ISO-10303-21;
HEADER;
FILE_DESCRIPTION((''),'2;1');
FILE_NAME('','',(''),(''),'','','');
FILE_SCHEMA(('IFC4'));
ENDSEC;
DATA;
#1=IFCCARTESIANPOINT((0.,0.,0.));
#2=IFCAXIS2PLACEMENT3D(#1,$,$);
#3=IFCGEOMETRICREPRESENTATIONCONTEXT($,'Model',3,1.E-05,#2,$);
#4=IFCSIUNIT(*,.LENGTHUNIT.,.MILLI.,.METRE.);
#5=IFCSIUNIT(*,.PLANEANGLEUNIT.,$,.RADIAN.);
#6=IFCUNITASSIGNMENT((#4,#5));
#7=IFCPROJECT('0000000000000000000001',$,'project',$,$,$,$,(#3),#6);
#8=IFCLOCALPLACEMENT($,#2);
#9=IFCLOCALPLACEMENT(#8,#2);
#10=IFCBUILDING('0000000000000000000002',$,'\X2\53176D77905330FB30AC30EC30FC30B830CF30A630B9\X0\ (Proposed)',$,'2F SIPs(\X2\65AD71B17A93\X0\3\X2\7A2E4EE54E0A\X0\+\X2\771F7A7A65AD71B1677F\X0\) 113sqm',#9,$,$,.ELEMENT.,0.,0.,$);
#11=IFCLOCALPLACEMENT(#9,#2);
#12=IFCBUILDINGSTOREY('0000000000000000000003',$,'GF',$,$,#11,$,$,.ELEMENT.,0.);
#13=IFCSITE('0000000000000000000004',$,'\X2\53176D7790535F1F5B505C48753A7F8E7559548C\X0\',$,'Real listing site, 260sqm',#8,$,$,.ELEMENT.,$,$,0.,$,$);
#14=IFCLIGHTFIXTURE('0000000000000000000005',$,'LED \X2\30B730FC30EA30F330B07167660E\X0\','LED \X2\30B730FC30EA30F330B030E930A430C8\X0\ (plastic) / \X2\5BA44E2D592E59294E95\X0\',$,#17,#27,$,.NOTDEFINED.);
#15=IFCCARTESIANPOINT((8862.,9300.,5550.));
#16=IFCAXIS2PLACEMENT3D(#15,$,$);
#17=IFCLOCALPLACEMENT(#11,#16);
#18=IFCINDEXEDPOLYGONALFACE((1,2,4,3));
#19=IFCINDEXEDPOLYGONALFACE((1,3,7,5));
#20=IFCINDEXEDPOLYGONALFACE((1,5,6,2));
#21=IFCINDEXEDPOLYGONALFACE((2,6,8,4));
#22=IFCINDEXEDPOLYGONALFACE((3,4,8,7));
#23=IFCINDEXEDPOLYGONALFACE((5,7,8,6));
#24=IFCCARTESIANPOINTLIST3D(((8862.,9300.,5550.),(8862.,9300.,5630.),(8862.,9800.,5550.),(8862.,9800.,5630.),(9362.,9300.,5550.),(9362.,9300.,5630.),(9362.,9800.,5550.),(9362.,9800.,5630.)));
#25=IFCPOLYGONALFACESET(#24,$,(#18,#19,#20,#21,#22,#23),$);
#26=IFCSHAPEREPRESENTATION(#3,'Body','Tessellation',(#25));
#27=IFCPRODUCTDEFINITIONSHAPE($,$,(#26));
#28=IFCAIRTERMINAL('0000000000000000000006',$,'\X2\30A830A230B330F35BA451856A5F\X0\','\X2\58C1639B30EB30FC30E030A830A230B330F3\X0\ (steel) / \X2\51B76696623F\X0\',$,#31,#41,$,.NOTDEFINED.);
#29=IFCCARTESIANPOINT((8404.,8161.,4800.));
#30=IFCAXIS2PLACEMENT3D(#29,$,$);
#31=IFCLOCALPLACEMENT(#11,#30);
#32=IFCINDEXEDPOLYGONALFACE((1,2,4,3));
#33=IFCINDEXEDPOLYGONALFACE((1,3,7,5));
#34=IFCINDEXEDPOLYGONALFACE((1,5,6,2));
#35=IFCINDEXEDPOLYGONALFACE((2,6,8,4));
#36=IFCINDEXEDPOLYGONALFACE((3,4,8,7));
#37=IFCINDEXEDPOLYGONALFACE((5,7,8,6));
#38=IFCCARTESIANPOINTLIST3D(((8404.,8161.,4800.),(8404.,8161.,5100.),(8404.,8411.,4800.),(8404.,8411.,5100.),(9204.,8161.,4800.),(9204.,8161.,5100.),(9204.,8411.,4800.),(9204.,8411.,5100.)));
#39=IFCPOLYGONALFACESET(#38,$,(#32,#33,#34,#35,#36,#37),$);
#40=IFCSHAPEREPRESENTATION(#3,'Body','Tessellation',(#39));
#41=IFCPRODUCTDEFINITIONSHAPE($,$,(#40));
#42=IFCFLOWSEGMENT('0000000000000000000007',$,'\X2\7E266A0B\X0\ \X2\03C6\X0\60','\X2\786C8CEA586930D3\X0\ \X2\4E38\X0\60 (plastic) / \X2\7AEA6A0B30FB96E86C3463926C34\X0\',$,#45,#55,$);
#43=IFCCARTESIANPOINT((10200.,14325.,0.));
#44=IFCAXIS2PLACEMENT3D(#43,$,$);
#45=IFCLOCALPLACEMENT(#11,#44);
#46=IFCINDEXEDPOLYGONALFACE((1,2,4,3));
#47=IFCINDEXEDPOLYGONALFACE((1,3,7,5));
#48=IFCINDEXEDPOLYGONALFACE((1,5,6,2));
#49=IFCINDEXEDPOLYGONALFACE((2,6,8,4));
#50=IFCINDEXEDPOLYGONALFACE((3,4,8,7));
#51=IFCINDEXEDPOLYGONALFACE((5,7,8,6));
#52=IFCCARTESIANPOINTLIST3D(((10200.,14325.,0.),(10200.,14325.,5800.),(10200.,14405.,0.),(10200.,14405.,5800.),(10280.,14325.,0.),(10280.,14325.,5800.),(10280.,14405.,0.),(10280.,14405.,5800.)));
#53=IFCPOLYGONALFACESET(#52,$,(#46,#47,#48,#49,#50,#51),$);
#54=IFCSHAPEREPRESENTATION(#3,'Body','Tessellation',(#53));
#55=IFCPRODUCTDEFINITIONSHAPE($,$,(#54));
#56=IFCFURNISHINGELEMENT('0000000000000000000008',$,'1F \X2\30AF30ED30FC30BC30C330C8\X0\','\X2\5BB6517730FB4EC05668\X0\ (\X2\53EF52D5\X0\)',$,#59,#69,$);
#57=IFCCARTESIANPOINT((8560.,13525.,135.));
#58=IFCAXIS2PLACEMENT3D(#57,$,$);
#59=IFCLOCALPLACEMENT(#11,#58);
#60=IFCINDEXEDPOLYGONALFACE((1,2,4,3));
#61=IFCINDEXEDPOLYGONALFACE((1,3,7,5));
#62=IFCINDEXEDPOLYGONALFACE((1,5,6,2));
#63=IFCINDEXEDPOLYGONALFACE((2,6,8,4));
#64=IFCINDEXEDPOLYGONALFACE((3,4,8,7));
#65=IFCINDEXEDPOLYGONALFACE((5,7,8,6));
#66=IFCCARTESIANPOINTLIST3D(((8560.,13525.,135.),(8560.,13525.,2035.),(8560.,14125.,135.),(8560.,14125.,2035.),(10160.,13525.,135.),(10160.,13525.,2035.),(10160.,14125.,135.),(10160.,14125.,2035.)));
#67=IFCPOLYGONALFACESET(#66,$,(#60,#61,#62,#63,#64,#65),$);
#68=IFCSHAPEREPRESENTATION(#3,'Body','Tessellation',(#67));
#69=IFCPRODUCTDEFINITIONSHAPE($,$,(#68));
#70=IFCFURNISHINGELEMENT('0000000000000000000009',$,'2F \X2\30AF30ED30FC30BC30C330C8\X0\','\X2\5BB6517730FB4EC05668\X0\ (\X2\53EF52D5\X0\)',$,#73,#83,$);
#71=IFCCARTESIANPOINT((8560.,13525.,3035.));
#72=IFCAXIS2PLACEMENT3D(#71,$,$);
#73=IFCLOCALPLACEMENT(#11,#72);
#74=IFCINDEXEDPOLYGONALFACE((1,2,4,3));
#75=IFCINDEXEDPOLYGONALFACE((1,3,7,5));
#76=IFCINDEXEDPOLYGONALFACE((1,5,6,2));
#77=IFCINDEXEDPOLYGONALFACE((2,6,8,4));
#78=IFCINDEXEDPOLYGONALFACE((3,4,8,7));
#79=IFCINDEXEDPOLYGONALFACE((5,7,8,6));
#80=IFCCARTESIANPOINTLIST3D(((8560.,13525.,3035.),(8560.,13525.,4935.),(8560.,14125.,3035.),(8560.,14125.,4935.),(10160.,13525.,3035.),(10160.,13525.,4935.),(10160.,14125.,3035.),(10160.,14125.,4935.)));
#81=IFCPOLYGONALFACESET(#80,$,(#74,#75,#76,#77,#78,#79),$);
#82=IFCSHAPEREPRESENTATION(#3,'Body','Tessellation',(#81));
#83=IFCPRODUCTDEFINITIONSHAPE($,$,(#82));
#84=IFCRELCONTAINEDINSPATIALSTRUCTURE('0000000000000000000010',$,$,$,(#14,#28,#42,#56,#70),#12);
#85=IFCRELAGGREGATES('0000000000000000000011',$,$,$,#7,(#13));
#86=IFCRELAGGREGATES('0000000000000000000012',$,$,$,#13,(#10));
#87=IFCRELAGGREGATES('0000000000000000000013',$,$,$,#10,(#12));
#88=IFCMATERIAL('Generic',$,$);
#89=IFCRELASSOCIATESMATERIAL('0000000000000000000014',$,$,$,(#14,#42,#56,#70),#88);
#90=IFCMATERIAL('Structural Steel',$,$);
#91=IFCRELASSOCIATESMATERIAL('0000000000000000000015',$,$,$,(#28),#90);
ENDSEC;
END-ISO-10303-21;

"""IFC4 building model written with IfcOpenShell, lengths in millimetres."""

from ifc_helpers import new_model, si_unit, frame, frame_2d, origin, place, context, project, spatial, rectangle, extrude, material, element, save


model = new_model("IFC4")

# Units and contexts
model_context = context("Model", 3, precision=1e-05, world=origin())
ifc_project = project(units=[si_unit("LENGTHUNIT", "METRE", prefix="MILLI"), si_unit("PLANEANGLEUNIT", "RADIAN")], contexts=[model_context])

# Site, building, storey
site_placement = place(None, origin())
site = spatial("IfcSite", under=ifc_project, at=site_placement, Name="北海道弟子屈町美留和", ObjectType="Real listing site, 260sqm", CompositionType="ELEMENT", RefElevation=0.0)
building_placement = place(site_placement, origin())
building = spatial("IfcBuilding", under=site, at=building_placement, Name="北海道・ガレージハウス (Proposed)", ObjectType="2F SIPs(断熱窓3種以上+真空断熱板) 113sqm", CompositionType="ELEMENT", ElevationOfRefHeight=0.0, ElevationOfTerrain=0.0)
storey_placement = place(building_placement, origin())
storey = spatial("IfcBuildingStorey", under=building, at=storey_placement, Name="GF", CompositionType="ELEMENT", Elevation=0.0)

# Shared definitions
ifc_material_1 = material(Name="Structural Steel")

# Light fixture
ifc_material_2 = material(Name="Generic")
light_fixture_1_placement = place(storey_placement, frame((8862.0, 9300.0, 5550.0)))
element("IfcLightFixture", 1, at=light_fixture_1_placement, inside=storey, material=ifc_material_2, Name="LED シーリング照明", Description="LED シーリングライト (plastic) / 室中央天井", PredefinedType="NOTDEFINED", context=model_context, shape_type="SweptSolid", body=[
    extrude(rectangle(XDim=500.0, YDim=500.0, at=frame_2d((250.0, 250.0))), frame((8862.0, 9300.0, 5550.0)), (0.0, 0.0, 1.0), 80.0),
])

# Air terminal
air_terminal_placement = place(storey_placement, frame((8404.0, 8161.0, 4800.0)))
element("IfcAirTerminal", 2, at=air_terminal_placement, inside=storey, material=ifc_material_1, Name="エアコン室内機", Description="壁掛ルームエアコン (steel) / 冷暖房", PredefinedType="NOTDEFINED", context=model_context, shape_type="SweptSolid", body=[
    extrude(rectangle(XDim=800.0, YDim=250.0, at=frame_2d((400.0, 125.0))), frame((8404.0, 8161.0, 4800.0)), (0.0, 0.0, 1.0), 300.0),
])

# Flow segment
flow_segment_placement = place(storey_placement, frame((10200.0, 14325.0, 0.0)))
element("IfcFlowSegment", 3, at=flow_segment_placement, inside=storey, material=ifc_material_2, Name="縦樋 φ60", Description="硬質塩ビ 丸60 (plastic) / 竪樋・雨水排水", context=model_context, shape_type="SweptSolid", body=[
    extrude(rectangle(XDim=80.0, YDim=80.0, at=frame_2d((40.0, 40.0))), frame((10200.0, 14325.0, 0.0)), (0.0, 0.0, 1.0), 5800.0),
])

# Furnishing elements
furnishing_1_placement = place(storey_placement, frame((8560.0, 13525.0, 135.0)))
element("IfcFurnishingElement", 4, at=furnishing_1_placement, inside=storey, material=ifc_material_2, Name="1F クローゼット", Description="家具・什器 (可動)", context=model_context, shape_type="SweptSolid", body=[
    extrude(rectangle(XDim=1600.0, YDim=600.0, at=frame_2d((800.0, 300.0))), frame((8560.0, 13525.0, 135.0)), (0.0, 0.0, 1.0), 1900.0),
])
furnishing_2_placement = place(storey_placement, frame((8560.0, 13525.0, 3035.0)))
element("IfcFurnishingElement", 5, at=furnishing_2_placement, inside=storey, material=ifc_material_2, Name="2F クローゼット", Description="家具・什器 (可動)", context=model_context, shape_type="SweptSolid", body=[
    extrude(rectangle(XDim=1600.0, YDim=600.0, at=frame_2d((800.0, 300.0))), frame((8560.0, 13525.0, 3035.0)), (0.0, 0.0, 1.0), 1900.0),
])

save(model, "model.ifc")
